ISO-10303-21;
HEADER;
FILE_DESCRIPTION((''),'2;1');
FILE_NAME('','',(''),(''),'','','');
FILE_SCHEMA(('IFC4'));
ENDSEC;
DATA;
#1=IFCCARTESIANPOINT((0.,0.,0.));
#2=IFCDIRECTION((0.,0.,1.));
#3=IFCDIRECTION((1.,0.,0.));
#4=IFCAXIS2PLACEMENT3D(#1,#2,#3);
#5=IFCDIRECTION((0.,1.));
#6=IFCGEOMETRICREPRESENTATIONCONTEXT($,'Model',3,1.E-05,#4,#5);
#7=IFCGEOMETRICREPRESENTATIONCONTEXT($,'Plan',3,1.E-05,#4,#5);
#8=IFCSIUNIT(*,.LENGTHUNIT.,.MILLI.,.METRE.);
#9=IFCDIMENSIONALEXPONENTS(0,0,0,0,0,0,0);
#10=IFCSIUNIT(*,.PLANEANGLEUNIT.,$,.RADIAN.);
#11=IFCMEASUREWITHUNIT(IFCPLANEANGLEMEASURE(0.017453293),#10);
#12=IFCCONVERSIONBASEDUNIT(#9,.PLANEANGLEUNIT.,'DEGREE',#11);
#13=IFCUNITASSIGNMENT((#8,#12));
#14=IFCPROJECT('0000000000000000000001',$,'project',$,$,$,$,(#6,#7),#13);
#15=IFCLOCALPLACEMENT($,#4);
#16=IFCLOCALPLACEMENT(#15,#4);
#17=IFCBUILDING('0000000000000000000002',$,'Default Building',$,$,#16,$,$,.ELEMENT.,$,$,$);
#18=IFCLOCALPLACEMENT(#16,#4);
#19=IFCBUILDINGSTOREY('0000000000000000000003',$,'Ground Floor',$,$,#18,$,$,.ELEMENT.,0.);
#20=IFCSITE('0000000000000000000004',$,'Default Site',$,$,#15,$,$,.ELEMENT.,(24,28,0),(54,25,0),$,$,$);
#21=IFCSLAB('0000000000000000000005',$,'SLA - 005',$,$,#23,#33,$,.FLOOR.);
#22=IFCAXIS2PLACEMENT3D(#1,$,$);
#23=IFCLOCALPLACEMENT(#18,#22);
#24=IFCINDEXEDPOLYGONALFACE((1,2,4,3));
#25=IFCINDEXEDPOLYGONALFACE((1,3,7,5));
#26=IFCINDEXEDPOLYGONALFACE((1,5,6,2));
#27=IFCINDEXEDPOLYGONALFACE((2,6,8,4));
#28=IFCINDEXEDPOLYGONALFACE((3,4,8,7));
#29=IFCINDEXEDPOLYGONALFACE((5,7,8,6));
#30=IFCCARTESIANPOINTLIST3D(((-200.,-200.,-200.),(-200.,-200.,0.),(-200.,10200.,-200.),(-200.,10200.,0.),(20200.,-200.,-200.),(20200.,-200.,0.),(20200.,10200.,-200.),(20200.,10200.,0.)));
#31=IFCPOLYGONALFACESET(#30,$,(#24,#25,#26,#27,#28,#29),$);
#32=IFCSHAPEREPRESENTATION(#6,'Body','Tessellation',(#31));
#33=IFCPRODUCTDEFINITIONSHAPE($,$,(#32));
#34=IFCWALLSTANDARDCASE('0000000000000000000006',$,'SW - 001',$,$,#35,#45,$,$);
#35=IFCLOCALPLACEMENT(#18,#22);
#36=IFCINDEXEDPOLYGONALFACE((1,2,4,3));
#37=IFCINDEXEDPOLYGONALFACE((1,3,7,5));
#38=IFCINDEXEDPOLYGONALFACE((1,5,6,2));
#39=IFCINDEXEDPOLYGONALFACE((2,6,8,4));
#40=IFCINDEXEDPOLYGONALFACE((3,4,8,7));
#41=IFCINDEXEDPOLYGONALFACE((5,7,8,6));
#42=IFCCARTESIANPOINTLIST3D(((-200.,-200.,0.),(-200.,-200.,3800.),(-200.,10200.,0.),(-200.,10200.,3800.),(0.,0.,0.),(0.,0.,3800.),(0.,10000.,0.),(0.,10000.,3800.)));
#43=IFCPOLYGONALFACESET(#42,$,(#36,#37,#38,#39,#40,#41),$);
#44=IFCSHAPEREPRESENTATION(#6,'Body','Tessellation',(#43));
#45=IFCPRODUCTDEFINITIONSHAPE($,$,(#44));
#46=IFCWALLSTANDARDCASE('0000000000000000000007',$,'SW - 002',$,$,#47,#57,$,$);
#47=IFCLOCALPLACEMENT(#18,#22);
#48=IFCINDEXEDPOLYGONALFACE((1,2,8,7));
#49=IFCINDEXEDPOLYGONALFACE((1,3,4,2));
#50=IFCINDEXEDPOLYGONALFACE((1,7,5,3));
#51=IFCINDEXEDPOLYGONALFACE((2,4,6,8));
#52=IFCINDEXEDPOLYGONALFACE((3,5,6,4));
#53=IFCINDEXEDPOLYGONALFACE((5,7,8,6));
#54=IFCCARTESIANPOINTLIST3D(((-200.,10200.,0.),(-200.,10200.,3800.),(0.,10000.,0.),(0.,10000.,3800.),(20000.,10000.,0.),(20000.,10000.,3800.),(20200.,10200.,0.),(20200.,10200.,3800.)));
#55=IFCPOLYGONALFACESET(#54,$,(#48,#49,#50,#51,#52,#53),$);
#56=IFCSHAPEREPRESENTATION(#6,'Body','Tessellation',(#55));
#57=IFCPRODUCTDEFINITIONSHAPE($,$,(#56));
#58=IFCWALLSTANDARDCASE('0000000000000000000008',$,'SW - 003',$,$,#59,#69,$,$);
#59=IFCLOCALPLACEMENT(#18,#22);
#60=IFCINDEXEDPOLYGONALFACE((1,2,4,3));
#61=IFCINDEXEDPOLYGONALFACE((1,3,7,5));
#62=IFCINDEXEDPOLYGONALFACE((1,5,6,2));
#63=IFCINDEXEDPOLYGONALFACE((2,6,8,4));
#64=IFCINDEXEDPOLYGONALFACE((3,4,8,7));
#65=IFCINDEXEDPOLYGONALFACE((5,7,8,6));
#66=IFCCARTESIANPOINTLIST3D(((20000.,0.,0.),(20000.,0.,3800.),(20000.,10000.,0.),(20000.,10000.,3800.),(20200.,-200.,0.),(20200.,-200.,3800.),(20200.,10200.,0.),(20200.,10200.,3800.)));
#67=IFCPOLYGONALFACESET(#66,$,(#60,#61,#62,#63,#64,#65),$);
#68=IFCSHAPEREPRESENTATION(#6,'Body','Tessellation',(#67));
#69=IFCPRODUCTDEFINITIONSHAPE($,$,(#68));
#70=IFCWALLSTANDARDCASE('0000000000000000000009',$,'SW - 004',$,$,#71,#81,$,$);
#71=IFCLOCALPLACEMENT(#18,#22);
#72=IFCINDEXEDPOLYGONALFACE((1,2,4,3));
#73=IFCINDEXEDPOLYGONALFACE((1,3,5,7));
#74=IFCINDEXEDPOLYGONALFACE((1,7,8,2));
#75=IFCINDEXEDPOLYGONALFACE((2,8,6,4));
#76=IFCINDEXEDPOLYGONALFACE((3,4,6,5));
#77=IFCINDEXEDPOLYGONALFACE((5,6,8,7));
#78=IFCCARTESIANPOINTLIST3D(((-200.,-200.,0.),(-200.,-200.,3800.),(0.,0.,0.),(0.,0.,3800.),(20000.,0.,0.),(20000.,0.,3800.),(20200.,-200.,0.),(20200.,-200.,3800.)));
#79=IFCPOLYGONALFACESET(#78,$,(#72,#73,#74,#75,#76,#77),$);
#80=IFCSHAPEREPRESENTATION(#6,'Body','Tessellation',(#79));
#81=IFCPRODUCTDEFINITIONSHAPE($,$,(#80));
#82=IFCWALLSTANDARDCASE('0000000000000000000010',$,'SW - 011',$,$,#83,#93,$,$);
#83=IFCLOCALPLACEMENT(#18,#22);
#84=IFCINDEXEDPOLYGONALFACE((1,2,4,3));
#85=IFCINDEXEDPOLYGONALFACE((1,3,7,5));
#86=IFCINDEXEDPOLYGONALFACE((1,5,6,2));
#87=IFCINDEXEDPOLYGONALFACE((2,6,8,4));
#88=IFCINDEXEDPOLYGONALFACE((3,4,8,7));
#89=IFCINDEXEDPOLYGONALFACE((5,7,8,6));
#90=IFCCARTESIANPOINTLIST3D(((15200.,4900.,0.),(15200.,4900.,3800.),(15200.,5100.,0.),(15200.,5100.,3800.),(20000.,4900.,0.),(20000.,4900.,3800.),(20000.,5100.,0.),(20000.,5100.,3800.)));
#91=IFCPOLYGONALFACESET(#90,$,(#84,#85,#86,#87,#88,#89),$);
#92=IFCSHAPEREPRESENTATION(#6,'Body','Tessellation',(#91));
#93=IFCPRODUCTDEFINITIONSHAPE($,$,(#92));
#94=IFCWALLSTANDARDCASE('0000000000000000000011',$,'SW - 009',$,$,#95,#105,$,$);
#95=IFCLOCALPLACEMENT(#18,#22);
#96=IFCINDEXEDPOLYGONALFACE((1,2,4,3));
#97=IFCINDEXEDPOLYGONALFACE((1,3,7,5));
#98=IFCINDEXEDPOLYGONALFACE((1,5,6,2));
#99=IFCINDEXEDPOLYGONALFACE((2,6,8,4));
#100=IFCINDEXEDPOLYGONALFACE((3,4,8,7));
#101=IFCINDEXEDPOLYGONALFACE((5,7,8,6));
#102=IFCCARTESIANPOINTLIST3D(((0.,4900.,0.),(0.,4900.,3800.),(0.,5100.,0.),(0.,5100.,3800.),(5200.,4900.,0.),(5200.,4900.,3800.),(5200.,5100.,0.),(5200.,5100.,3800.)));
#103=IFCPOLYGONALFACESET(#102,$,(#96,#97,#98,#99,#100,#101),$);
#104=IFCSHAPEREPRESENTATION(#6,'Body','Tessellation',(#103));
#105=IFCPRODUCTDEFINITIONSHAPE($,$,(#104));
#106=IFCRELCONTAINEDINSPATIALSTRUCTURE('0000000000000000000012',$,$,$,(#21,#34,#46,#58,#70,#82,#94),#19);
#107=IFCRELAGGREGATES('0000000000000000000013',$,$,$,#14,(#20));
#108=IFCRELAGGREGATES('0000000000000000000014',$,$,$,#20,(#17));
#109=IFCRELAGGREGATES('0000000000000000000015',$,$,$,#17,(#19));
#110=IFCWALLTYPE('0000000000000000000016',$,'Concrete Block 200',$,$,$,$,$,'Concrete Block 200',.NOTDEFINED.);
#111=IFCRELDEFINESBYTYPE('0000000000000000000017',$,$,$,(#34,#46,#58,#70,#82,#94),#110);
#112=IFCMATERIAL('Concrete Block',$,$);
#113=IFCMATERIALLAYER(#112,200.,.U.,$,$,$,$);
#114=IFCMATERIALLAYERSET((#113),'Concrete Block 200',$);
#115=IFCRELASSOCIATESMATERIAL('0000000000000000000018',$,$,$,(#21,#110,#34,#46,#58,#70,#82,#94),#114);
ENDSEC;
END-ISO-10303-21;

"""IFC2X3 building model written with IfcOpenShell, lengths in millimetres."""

from ifc_helpers import new_model, entity, si_unit, converted_unit, direction, frame, origin_with_axes, place, context, project, spatial, polyline, outline, extrude, material, layer, layer_set, layer_usage, type_object, element, save


model = new_model("IFC2X3")

# Units and contexts
model_context = context("Model", 3, precision=1e-05, world=origin_with_axes(), true_north=direction((0.0, 1.0)))
plan_context = context("Plan", 3, precision=1e-05, world=origin_with_axes(), true_north=direction((0.0, 1.0)))
ifc_project = project(units=[si_unit("LENGTHUNIT", "METRE", prefix="MILLI"), converted_unit("PLANEANGLEUNIT", "DEGREE", entity("IfcPlaneAngleMeasure", 0.017453293), si_unit("PLANEANGLEUNIT", "RADIAN"), dimensions=[0, 0, 0, 0, 0, 0, 0])], contexts=[model_context, plan_context])

# Site, building, storey
site_placement = place(None, origin_with_axes())
site = spatial("IfcSite", under=ifc_project, at=site_placement, Name="Default Site", CompositionType="ELEMENT", RefLatitude=(24, 28, 0), RefLongitude=(54, 25, 0))
building_placement = place(site_placement, origin_with_axes())
building = spatial("IfcBuilding", under=site, at=building_placement, Name="Default Building", CompositionType="ELEMENT")
storey_placement = place(building_placement, origin_with_axes())
storey = spatial("IfcBuildingStorey", under=building, at=storey_placement, Name="Ground Floor", CompositionType="ELEMENT", Elevation=0.0)

# Slab
ifc_material = material(Name="Concrete Block")
ifc_layer = layer(ifc_material, 200.0, ventilated="UNKNOWN")
ifc_layer_set = layer_set([ifc_layer], Name="Concrete Block 200")
ifc_layer_usage_1 = layer_usage(ifc_layer_set, "AXIS3", "NEGATIVE", 200.0)
slab_placement = place(storey_placement, frame((-200.0, 10200.0, -200.0), z_axis=(0.0, 0.0, 1.0), x_axis=(1.0, 0.0, 0.0)))
element("IfcSlab", 1, at=slab_placement, inside=storey, material=ifc_layer_usage_1, Name="SLA - 005", PredefinedType="FLOOR", context=model_context, shape_type="SweptSolid", body=[
    extrude(outline(polyline([(0.0, 0.0), (20400.0, 0.0), (20400.0, -10400.0), (0.0, -10400.0), (0.0, 0.0)])), origin_with_axes(), (0.0, 0.0, 1.0), 200.0),
])

# Walls
ifc_layer_usage_2 = layer_usage(ifc_layer_set, "AXIS2", "POSITIVE", 0.0)
wall_type = type_object("IfcWallType", Name="Concrete Block 200", ElementType="Concrete Block 200", PredefinedType="NOTDEFINED", material=ifc_layer_set)
wall_1_placement = place(storey_placement, frame((0.0, 0.0, 0.0), z_axis=(0.0, 0.0, 1.0), x_axis=(0.0, 1.0, 0.0)))
element("IfcWallStandardCase", 2, at=wall_1_placement, inside=storey, type_object=wall_type, material=ifc_layer_usage_2, Name="SW - 001", context=model_context, shape_type="SweptSolid", body=[
    extrude(outline(polyline([(0.0, 0.0), (10000.0, 0.0), (10200.0, 200.0), (-200.0, 200.0), (0.0, 0.0)])), origin_with_axes(), (0.0, 0.0, 1.0), 3800.0),
])
ifc_layer_usage_3 = layer_usage(ifc_layer_set, "AXIS2", "POSITIVE", 0.0)
wall_2_placement = place(storey_placement, frame((0.0, 10000.0, 0.0), z_axis=(0.0, 0.0, 1.0), x_axis=(1.0, 0.0, 0.0)))
element("IfcWallStandardCase", 3, at=wall_2_placement, inside=storey, type_object=wall_type, material=ifc_layer_usage_3, Name="SW - 002", context=model_context, shape_type="SweptSolid", body=[
    extrude(outline(polyline([(0.0, 0.0), (20000.0, 0.0), (20200.0, 200.0), (-200.0, 200.0), (0.0, 0.0)])), origin_with_axes(), (0.0, 0.0, 1.0), 3800.0),
])
ifc_layer_usage_4 = layer_usage(ifc_layer_set, "AXIS2", "POSITIVE", 0.0)
wall_3_placement = place(storey_placement, frame((20000.0, 10000.0, 0.0), z_axis=(0.0, 0.0, 1.0), x_axis=(0.0, -1.0, 0.0)))
element("IfcWallStandardCase", 4, at=wall_3_placement, inside=storey, type_object=wall_type, material=ifc_layer_usage_4, Name="SW - 003", context=model_context, shape_type="SweptSolid", body=[
    extrude(outline(polyline([(0.0, 0.0), (10000.0, 0.0), (10200.0, 200.0), (-200.0, 200.0), (0.0, 0.0)])), origin_with_axes(), (0.0, 0.0, 1.0), 3800.0),
])
ifc_layer_usage_5 = layer_usage(ifc_layer_set, "AXIS2", "POSITIVE", 0.0)
wall_4_placement = place(storey_placement, frame((20000.0, 0.0, 0.0), z_axis=(0.0, 0.0, 1.0), x_axis=(-1.0, 0.0, 0.0)))
element("IfcWallStandardCase", 5, at=wall_4_placement, inside=storey, type_object=wall_type, material=ifc_layer_usage_5, Name="SW - 004", context=model_context, shape_type="SweptSolid", body=[
    extrude(outline(polyline([(0.0, 0.0), (20000.0, 0.0), (20200.0, 200.0), (-200.0, 200.0), (0.0, 0.0)])), origin_with_axes(), (0.0, 0.0, 1.0), 3800.0),
])
ifc_layer_usage_6 = layer_usage(ifc_layer_set, "AXIS2", "NEGATIVE", 100.0)
wall_5_placement = place(storey_placement, frame((15200.0, 5000.0, 0.0), z_axis=(0.0, 0.0, 1.0), x_axis=(1.0, 0.0, 0.0)))
element("IfcWallStandardCase", 6, at=wall_5_placement, inside=storey, type_object=wall_type, material=ifc_layer_usage_6, Name="SW - 011", context=model_context, shape_type="SweptSolid", body=[
    extrude(outline(polyline([(0.0, -100.0), (4800.0, -100.0), (4800.0, 100.0), (0.0, 100.0), (0.0, -100.0)])), origin_with_axes(), (0.0, 0.0, 1.0), 3800.0),
])
ifc_layer_usage_7 = layer_usage(ifc_layer_set, "AXIS2", "NEGATIVE", 100.0)
wall_6_placement = place(storey_placement, frame((5200.0, 5000.0, 0.0), z_axis=(0.0, 0.0, 1.0), x_axis=(-1.0, 0.0, 0.0)))
element("IfcWallStandardCase", 7, at=wall_6_placement, inside=storey, type_object=wall_type, material=ifc_layer_usage_7, Name="SW - 009", context=model_context, shape_type="SweptSolid", body=[
    extrude(outline(polyline([(0.0, -100.0), (5200.0, -100.0), (5200.0, 100.0), (0.0, 100.0), (0.0, -100.0)])), origin_with_axes(), (0.0, 0.0, 1.0), 3800.0),
])

save(model, "model.ifc")
